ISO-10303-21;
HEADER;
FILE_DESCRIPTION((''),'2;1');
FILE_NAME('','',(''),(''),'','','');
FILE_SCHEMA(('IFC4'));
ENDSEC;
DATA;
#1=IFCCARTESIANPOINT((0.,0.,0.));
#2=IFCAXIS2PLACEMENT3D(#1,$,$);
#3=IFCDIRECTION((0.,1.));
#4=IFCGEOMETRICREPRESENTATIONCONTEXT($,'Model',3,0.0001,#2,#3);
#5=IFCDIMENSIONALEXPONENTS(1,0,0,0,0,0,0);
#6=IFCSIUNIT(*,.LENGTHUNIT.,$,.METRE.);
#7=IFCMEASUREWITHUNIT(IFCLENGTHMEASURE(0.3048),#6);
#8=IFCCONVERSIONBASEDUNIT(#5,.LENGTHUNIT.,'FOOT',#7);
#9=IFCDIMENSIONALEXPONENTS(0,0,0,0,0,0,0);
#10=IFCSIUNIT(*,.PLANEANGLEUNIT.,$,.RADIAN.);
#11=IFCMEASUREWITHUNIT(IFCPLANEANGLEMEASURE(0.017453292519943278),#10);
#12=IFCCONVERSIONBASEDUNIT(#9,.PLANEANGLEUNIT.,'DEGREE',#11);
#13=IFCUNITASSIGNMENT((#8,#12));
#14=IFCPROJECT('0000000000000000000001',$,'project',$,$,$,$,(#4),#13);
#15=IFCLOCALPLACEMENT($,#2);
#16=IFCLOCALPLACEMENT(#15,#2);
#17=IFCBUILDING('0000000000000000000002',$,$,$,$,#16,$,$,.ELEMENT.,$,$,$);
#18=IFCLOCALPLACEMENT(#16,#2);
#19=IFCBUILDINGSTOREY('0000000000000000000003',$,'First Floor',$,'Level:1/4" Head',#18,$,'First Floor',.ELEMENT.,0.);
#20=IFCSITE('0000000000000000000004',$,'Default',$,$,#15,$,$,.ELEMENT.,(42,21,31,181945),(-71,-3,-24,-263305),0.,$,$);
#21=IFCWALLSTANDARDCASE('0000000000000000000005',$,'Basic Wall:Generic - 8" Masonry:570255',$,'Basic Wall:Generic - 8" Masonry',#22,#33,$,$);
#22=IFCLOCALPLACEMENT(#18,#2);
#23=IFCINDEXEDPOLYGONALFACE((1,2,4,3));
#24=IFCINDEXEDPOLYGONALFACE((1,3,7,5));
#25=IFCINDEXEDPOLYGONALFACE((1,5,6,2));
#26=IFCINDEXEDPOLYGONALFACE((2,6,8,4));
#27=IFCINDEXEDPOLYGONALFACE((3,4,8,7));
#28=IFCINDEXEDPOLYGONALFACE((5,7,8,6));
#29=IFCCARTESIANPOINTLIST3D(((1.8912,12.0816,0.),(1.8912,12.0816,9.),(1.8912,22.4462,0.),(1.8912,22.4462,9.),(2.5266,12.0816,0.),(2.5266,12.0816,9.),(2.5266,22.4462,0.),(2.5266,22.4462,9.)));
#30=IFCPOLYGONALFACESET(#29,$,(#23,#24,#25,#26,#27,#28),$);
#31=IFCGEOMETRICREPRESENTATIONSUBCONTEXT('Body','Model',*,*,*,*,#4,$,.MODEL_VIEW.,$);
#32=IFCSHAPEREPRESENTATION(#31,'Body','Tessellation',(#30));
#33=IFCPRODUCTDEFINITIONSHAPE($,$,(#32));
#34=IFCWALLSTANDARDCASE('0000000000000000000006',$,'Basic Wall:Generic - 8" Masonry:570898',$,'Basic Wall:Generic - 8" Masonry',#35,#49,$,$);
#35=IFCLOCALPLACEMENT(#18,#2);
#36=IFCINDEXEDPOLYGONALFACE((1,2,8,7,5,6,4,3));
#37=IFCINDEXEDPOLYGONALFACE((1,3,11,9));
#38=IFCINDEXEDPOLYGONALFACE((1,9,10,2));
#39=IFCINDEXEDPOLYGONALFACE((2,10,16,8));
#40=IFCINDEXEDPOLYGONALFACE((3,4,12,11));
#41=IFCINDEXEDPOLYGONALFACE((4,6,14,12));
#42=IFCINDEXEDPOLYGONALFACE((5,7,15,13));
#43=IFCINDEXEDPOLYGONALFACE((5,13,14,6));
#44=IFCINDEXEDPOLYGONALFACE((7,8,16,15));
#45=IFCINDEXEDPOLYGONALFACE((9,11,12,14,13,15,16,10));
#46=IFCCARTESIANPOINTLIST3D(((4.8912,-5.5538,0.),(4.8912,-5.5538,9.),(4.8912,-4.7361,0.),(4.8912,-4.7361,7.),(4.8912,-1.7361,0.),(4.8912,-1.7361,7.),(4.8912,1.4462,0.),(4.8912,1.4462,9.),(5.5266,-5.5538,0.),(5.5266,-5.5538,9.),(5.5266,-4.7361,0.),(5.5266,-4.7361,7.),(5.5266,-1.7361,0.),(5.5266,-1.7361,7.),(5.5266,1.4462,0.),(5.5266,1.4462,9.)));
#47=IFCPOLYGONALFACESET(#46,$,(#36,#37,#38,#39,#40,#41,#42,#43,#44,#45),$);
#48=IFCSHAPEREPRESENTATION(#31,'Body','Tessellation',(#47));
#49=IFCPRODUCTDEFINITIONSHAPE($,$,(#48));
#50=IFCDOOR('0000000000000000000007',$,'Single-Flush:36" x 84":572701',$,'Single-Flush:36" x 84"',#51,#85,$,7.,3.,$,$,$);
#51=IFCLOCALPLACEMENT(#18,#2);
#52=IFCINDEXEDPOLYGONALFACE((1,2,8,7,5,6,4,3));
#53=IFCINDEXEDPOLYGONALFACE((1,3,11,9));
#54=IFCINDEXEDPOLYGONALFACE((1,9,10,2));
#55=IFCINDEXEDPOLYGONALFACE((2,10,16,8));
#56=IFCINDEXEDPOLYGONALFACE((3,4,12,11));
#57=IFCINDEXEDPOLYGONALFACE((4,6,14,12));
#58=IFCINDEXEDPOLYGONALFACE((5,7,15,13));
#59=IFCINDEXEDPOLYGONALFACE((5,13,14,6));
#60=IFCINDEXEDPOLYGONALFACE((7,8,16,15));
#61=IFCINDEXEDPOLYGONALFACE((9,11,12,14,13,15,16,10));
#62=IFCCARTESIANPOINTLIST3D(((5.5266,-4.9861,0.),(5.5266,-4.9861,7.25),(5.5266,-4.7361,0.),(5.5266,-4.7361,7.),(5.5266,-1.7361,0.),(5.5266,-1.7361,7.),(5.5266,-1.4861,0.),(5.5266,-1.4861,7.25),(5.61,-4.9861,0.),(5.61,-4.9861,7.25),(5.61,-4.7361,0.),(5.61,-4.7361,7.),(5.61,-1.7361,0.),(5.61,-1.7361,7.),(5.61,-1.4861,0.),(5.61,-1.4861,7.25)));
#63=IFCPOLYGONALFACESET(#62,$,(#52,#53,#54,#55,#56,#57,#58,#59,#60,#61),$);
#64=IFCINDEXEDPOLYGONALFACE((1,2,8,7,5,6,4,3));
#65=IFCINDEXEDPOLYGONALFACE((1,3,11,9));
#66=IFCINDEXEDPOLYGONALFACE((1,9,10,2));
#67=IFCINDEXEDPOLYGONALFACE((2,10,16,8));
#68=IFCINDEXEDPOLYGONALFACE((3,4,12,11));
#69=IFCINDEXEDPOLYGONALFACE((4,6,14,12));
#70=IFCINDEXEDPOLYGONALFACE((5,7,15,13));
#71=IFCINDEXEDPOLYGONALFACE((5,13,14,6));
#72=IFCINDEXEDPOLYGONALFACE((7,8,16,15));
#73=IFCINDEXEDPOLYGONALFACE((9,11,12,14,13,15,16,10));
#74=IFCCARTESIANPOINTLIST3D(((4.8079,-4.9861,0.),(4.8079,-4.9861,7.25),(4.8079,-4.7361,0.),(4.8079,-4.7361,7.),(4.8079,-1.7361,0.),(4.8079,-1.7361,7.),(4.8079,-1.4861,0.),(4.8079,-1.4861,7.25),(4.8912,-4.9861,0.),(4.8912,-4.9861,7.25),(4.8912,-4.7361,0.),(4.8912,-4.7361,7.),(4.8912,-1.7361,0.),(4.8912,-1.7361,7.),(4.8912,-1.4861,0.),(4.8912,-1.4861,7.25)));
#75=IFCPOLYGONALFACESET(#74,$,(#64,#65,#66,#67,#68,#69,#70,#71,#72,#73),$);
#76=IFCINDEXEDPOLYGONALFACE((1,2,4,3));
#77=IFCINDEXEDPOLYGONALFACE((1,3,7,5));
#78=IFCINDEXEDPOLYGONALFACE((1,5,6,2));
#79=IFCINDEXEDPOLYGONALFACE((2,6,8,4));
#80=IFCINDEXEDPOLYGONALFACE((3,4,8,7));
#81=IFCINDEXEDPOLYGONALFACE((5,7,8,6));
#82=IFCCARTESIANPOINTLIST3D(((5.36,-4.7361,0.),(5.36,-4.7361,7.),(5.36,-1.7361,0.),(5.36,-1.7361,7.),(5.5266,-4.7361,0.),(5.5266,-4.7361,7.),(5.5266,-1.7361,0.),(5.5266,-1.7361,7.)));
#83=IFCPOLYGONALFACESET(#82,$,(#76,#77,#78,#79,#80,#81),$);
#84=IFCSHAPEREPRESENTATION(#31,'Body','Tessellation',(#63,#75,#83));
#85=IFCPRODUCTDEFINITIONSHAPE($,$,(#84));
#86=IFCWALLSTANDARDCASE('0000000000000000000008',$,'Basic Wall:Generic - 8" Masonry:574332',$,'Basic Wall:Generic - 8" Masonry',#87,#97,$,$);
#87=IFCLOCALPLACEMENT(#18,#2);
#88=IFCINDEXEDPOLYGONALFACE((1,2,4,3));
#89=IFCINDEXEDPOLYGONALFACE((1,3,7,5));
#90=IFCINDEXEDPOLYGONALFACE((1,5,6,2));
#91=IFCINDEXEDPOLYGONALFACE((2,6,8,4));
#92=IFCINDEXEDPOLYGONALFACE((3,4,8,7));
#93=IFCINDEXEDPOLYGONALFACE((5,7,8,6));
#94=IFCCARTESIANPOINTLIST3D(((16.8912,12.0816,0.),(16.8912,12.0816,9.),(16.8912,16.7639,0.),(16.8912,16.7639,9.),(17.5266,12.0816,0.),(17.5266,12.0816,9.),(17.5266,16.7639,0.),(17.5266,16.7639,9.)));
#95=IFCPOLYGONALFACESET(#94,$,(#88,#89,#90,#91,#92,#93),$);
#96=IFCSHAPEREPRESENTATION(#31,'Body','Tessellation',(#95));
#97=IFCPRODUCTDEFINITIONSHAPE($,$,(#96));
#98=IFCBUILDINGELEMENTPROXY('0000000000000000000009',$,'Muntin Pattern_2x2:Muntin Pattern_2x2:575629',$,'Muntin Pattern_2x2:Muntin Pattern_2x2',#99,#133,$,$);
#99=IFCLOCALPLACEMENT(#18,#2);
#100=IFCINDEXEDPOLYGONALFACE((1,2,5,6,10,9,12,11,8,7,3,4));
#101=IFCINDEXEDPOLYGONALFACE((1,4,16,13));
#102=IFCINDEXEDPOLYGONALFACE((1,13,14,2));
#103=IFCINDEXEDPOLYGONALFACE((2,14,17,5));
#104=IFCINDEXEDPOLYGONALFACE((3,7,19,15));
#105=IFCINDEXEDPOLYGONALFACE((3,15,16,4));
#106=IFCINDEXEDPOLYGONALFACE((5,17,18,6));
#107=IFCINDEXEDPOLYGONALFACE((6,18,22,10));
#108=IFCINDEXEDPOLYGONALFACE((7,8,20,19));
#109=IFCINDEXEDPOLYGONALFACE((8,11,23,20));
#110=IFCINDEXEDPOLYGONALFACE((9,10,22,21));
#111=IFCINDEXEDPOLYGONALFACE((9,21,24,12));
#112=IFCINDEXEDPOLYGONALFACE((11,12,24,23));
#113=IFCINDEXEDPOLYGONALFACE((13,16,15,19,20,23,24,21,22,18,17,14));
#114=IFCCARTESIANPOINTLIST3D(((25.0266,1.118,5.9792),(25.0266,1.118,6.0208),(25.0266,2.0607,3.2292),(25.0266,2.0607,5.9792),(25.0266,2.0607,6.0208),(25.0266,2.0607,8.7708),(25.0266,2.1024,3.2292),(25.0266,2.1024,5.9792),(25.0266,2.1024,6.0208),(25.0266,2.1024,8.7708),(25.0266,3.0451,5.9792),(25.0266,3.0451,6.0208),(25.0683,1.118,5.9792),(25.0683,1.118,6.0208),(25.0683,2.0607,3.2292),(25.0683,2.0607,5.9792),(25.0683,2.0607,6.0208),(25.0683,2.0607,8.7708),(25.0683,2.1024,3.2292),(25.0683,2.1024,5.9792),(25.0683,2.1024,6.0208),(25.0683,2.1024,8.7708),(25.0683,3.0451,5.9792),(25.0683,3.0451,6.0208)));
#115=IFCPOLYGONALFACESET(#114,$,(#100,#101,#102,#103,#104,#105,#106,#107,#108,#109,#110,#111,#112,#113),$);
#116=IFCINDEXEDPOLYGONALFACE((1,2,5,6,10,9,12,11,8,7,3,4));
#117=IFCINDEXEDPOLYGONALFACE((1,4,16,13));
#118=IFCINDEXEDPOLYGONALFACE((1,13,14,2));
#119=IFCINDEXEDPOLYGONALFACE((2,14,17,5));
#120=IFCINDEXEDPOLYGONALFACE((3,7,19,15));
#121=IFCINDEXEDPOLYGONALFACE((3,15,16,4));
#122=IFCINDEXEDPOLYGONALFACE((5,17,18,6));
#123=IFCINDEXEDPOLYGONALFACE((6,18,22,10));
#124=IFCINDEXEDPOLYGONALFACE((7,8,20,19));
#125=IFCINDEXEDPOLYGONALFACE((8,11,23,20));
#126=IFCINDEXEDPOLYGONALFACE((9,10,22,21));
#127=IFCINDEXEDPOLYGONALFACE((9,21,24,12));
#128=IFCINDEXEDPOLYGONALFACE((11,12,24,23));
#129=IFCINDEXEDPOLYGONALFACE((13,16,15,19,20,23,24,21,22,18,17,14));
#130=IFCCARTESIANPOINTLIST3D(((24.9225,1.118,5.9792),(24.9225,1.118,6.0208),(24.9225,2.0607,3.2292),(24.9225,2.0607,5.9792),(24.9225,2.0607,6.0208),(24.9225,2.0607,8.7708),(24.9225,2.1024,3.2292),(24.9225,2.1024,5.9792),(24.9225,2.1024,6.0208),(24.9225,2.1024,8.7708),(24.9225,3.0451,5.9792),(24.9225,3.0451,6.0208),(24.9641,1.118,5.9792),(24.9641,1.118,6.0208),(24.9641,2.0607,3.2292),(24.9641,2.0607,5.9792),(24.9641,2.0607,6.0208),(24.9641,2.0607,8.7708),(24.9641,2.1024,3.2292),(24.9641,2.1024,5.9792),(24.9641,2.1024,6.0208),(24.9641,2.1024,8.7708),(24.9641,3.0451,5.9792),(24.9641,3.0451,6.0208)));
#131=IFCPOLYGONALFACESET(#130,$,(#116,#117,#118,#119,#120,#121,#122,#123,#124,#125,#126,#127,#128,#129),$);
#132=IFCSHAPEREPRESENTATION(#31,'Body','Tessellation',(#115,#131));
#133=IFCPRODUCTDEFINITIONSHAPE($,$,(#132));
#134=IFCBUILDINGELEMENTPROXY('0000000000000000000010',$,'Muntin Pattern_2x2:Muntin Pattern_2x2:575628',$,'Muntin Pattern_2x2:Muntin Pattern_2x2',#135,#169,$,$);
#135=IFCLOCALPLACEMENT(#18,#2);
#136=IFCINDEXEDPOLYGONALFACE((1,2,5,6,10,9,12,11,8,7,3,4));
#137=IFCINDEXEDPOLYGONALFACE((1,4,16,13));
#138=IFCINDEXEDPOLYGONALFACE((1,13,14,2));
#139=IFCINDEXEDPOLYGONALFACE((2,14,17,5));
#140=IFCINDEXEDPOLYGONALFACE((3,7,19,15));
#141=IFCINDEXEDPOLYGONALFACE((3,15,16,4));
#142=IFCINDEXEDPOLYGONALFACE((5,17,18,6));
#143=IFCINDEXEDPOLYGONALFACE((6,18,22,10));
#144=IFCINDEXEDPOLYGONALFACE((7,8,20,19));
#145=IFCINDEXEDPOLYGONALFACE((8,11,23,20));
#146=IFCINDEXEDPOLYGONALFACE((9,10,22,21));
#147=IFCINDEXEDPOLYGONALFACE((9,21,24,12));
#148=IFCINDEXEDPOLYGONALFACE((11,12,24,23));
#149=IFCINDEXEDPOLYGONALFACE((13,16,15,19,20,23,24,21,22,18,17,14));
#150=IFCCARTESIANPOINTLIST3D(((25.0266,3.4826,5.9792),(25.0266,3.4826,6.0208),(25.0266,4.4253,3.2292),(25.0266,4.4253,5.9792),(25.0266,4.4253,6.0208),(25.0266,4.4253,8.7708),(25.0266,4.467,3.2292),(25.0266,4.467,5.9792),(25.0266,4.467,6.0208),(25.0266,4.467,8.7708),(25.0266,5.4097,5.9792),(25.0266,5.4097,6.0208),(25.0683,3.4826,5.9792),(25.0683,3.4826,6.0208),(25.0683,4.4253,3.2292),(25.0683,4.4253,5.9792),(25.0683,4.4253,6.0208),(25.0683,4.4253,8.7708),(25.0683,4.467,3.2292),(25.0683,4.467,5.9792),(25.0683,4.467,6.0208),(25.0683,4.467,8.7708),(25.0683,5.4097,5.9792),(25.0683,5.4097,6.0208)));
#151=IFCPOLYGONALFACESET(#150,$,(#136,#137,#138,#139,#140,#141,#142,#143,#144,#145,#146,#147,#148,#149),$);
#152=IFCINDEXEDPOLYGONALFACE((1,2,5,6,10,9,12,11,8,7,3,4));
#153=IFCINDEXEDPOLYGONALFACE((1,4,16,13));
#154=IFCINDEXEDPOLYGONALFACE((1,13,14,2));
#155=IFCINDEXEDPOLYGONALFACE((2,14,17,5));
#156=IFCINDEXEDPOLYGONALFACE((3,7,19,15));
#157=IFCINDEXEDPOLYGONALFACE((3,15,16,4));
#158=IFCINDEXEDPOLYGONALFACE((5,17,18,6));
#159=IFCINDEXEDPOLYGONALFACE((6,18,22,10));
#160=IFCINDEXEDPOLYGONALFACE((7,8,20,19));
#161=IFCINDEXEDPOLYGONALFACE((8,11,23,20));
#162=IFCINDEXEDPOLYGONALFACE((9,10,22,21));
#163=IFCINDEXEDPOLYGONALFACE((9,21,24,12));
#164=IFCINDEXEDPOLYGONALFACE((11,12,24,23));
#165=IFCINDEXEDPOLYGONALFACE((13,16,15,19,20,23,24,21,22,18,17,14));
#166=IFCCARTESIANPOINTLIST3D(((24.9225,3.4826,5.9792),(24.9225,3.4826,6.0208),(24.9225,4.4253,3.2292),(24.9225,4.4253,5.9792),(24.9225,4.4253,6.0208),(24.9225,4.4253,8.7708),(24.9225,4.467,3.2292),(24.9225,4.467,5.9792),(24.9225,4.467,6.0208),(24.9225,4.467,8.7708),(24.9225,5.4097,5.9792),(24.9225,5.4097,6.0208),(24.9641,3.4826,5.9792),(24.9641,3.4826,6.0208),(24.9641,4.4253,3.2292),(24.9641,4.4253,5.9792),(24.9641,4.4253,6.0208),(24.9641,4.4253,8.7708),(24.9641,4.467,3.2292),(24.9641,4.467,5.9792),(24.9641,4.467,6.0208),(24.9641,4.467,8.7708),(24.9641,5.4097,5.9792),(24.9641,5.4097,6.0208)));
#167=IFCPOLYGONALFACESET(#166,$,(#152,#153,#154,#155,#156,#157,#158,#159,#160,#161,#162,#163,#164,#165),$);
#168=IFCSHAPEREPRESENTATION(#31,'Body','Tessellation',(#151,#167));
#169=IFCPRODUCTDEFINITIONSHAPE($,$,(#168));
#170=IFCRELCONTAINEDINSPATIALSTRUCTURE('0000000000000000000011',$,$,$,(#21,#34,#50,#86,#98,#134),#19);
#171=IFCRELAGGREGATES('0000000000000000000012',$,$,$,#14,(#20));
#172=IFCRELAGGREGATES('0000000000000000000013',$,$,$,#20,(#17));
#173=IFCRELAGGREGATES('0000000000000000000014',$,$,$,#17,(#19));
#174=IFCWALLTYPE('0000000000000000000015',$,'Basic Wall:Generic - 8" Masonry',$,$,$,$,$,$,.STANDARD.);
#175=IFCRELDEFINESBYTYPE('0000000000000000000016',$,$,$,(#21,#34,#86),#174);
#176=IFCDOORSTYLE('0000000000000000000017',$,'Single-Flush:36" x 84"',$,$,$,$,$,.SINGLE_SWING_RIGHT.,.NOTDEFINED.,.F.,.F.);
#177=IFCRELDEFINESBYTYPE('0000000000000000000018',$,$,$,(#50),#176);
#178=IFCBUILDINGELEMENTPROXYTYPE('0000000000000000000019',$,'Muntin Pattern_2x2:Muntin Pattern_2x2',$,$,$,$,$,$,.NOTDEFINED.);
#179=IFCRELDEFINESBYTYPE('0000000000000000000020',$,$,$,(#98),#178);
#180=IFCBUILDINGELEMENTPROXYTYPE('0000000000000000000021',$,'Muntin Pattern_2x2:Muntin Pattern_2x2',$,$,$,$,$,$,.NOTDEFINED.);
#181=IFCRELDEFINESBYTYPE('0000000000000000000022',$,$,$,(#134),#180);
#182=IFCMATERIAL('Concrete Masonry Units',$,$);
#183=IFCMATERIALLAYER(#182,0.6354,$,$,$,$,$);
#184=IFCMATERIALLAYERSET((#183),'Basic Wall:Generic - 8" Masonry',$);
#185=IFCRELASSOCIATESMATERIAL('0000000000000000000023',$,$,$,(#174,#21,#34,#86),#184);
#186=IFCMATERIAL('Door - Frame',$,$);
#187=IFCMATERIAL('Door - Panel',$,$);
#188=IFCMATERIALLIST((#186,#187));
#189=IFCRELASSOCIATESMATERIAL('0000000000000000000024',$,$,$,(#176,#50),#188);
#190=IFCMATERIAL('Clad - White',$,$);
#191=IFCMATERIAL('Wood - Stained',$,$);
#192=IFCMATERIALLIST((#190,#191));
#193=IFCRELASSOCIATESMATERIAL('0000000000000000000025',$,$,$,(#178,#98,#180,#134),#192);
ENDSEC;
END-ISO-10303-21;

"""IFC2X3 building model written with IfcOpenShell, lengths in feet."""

from ifc_helpers import new_model, entity, si_unit, converted_unit, direction, frame, frame_2d, origin, place, context, subcontext, project, spatial, polyline, rectangle, outline, extrude, source, transform, mapped, material, material_list, layer, layer_set, layer_usage, type_object, type_shapes, element, fill, save


model = new_model("IFC2X3")

# Units and contexts
model_context = context("Model", 3, precision=0.0001, world=origin(), true_north=direction((0.0, 1.0)))
body_context = subcontext(model_context, "Body", "Model", "MODEL_VIEW")
ifc_project = project(units=[converted_unit("LENGTHUNIT", "FOOT", entity("IfcLengthMeasure", 0.3048), si_unit("LENGTHUNIT", "METRE"), dimensions=[1, 0, 0, 0, 0, 0, 0]), converted_unit("PLANEANGLEUNIT", "DEGREE", entity("IfcPlaneAngleMeasure", 0.017453292519943278), si_unit("PLANEANGLEUNIT", "RADIAN"), dimensions=[0, 0, 0, 0, 0, 0, 0])], contexts=[model_context])

# Site, building, storey
site_placement = place(None, origin())
site = spatial("IfcSite", under=ifc_project, at=site_placement, Name="Default", CompositionType="ELEMENT", RefLatitude=(42, 21, 31, 181945), RefLongitude=(-71, -3, -24, -263305), RefElevation=0.0)
building_placement = place(site_placement, origin())
building = spatial("IfcBuilding", under=site, at=building_placement, CompositionType="ELEMENT")
storey_placement = place(building_placement, origin())
storey = spatial("IfcBuildingStorey", under=building, at=storey_placement, Name="First Floor", ObjectType="Level:1/4\" Head", LongName="First Floor", CompositionType="ELEMENT", Elevation=0.0)

# Shared definitions
ifc_material_1 = material(Name="Concrete Masonry Units")
ifc_layer = layer(ifc_material_1, 0.6354)
ifc_layer_set = layer_set([ifc_layer], Name="Basic Wall:Generic - 8\" Masonry")
wall_type = type_object("IfcWallType", Name="Basic Wall:Generic - 8\" Masonry", PredefinedType="STANDARD", material=ifc_layer_set)

# Wall
ifc_layer_usage_1 = layer_usage(ifc_layer_set, "AXIS2", "NEGATIVE", 0.3177)
wall_1_placement = place(storey_placement, frame((2.2089, 22.4462, 0.0), z_axis=(0.0, 0.0, 1.0), x_axis=(0.0, -1.0, 0.0)))
element("IfcWallStandardCase", 1, at=wall_1_placement, inside=storey, type_object=wall_type, material=ifc_layer_usage_1, Name="Basic Wall:Generic - 8\" Masonry:570255", ObjectType="Basic Wall:Generic - 8\" Masonry", context=body_context, shape_type="SweptSolid", body=[
    extrude(rectangle(XDim=10.3646, YDim=0.6354, at=frame_2d((5.1823, 0.0), x_axis=(-1.0, 0.0))), origin(), (0.0, 0.0, 1.0), 9.0),
])

# Wall, opening, door
ifc_layer_usage_2 = layer_usage(ifc_layer_set, "AXIS2", "NEGATIVE", 0.3177)
wall_2_placement = place(storey_placement, frame((5.2089, 1.4462, 0.0), z_axis=(0.0, 0.0, 1.0), x_axis=(0.0, -1.0, 0.0)))
wall_2 = element("IfcWallStandardCase", 2, at=wall_2_placement, inside=storey, type_object=wall_type, material=ifc_layer_usage_2, Name="Basic Wall:Generic - 8\" Masonry:570898", ObjectType="Basic Wall:Generic - 8\" Masonry", context=body_context, shape_type="SweptSolid", body=[
    extrude(rectangle(XDim=7.0, YDim=0.6354, at=frame_2d((3.5, 0.0), x_axis=(1.0, 0.0))), origin(), (0.0, 0.0, 1.0), 9.0),
])
opening_1_placement = place(wall_2_placement, frame((3.1823, -0.3177, 0.0)))
opening_1 = element("IfcOpeningElement", 3, at=opening_1_placement, cuts=wall_2, ObjectType="Opening", context=body_context, shape_type="SweptSolid", body=[
    extrude(rectangle(XDim=3.0, YDim=7.0, at=frame_2d((3.5, 1.5), x_axis=(0.0, 1.0))), frame((0.0, 0.0, 0.0), z_axis=(0.0, 1.0, 0.0), x_axis=(0.0, 0.0, 1.0)), (0.0, 0.0, 1.0), 0.6354),
])
ifc_material_2 = material(Name="Door - Frame")
ifc_material_3 = material(Name="Door - Panel")
ifc_material_list_1 = material_list([ifc_material_2, ifc_material_3])
door_style = type_object("IfcDoorStyle", Name="Single-Flush:36\" x 84\"", ConstructionType="NOTDEFINED", OperationType="SINGLE_SWING_RIGHT", ParameterTakesPrecedence=False, Sizeable=False, material=ifc_material_list_1)
shared_shape_1 = source(origin(), body_context, "Body", "SweptSolid", [
    extrude(outline(polyline([(-1.75, -3.6875), (1.75, -3.6875), (1.75, 3.5625), (1.5, 3.5625), (1.5, -3.4375), (-1.5, -3.4375), (-1.5, 3.5625), (-1.75, 3.5625), (-1.75, -3.6875)])), frame((1.5, 0.6354, 3.5625), z_axis=(0.0, 1.0, 0.0), x_axis=(1.0, 0.0, 0.0)), (0.0, 0.0, 1.0), 0.0833),
    extrude(outline(polyline([(-3.6875, -1.75), (3.5625, -1.75), (3.5625, -1.5), (-3.4375, -1.5), (-3.4375, 1.5), (3.5625, 1.5), (3.5625, 1.75), (-3.6875, 1.75), (-3.6875, -1.75)])), frame((1.5, -0.0833, 3.5625), z_axis=(0.0, 1.0, 0.0), x_axis=(0.0, 0.0, -1.0)), (0.0, 0.0, 1.0), 0.0833),
    extrude(rectangle(XDim=0.1667, YDim=3.0, at=frame_2d((0.0, 0.0), x_axis=(1.0, 0.0))), frame((1.5, 0.5521, 0.0), z_axis=(0.0, 0.0, 1.0), x_axis=(0.0, 1.0, 0.0)), (0.0, 0.0, 1.0), 7.0),
])
type_shapes(door_style, [shared_shape_1])
door_placement = place(opening_1_placement, origin())
door = element("IfcDoor", 4, at=door_placement, inside=storey, type_object=door_style, material=ifc_material_list_1, Name="Single-Flush:36\" x 84\":572701", ObjectType="Single-Flush:36\" x 84\"", OverallHeight=7.0, OverallWidth=3.0, context=body_context, shape_type="MappedRepresentation", body=[
    mapped(shared_shape_1, transform((0.0, 0.0, 0.0), scale=1.0)),
])
fill(opening_1, door)

# Wall
ifc_layer_usage_3 = layer_usage(ifc_layer_set, "AXIS2", "NEGATIVE", 0.3177)
wall_3_placement = place(storey_placement, frame((17.2089, 12.0816, 0.0), z_axis=(0.0, 0.0, 1.0), x_axis=(0.0, 1.0, 0.0)))
element("IfcWallStandardCase", 5, at=wall_3_placement, inside=storey, type_object=wall_type, material=ifc_layer_usage_3, Name="Basic Wall:Generic - 8\" Masonry:574332", ObjectType="Basic Wall:Generic - 8\" Masonry", context=body_context, shape_type="SweptSolid", body=[
    extrude(rectangle(XDim=4.6823, YDim=0.6354, at=frame_2d((2.3411, 0.0), x_axis=(-1.0, 0.0))), origin(), (0.0, 0.0, 1.0), 9.0),
])

# Building element proxies
ifc_material_4 = material(Name="Clad - White")
ifc_material_5 = material(Name="Wood - Stained")
ifc_material_list_2 = material_list([ifc_material_4, ifc_material_5])
building_element_proxy_type_1 = type_object("IfcBuildingElementProxyType", Name="Muntin Pattern_2x2:Muntin Pattern_2x2", PredefinedType="NOTDEFINED", material=ifc_material_list_2)
shared_shape_2 = source(origin(), body_context, "Body", "SweptSolid", [
    extrude(outline(polyline([(0.0208, -0.0208), (2.7708, -0.0208), (2.7708, 0.0208), (0.0208, 0.0208), (0.0208, 0.9635), (-0.0208, 0.9635), (-0.0208, 0.0208), (-2.7708, 0.0208), (-2.7708, -0.0208), (-0.0208, -0.0208), (-0.0208, -0.9635), (0.0208, -0.9635), (0.0208, -0.0208)])), frame((0.0, -0.0729, 2.7708), z_axis=(0.0, 1.0, 0.0), x_axis=(0.0, 0.0, 1.0)), (0.0, 0.0, 1.0), 0.0417),
    extrude(outline(polyline([(0.0208, -0.0208), (2.7708, -0.0208), (2.7708, 0.0208), (0.0208, 0.0208), (0.0208, 0.9635), (-0.0208, 0.9635), (-0.0208, 0.0208), (-2.7708, 0.0208), (-2.7708, -0.0208), (-0.0208, -0.0208), (-0.0208, -0.9635), (0.0208, -0.9635), (0.0208, -0.0208)])), frame((0.0, 0.0313, 2.7708), z_axis=(0.0, 1.0, 0.0), x_axis=(0.0, 0.0, 1.0)), (0.0, 0.0, 1.0), 0.0417),
])
type_shapes(building_element_proxy_type_1, [shared_shape_2])
proxy_1_placement = place(storey_placement, frame((24.9954, 2.0816, 3.2292), z_axis=(0.0, 0.0, 1.0), x_axis=(0.0, 1.0, 0.0)))
element("IfcBuildingElementProxy", 6, at=proxy_1_placement, inside=storey, type_object=building_element_proxy_type_1, material=ifc_material_list_2, Name="Muntin Pattern_2x2:Muntin Pattern_2x2:575629", ObjectType="Muntin Pattern_2x2:Muntin Pattern_2x2", context=body_context, shape_type="MappedRepresentation", body=[
    mapped(shared_shape_2, transform((0.0, 0.0, 0.0), scale=1.0)),
])
building_element_proxy_type_2 = type_object("IfcBuildingElementProxyType", Name="Muntin Pattern_2x2:Muntin Pattern_2x2", PredefinedType="NOTDEFINED", material=ifc_material_list_2)
shared_shape_3 = source(origin(), body_context, "Body", "SweptSolid", [
    extrude(outline(polyline([(0.0208, -0.0208), (2.7708, -0.0208), (2.7708, 0.0208), (0.0208, 0.0208), (0.0208, 0.9635), (-0.0208, 0.9635), (-0.0208, 0.0208), (-2.7708, 0.0208), (-2.7708, -0.0208), (-0.0208, -0.0208), (-0.0208, -0.9635), (0.0208, -0.9635), (0.0208, -0.0208)])), frame((0.0, 0.0313, 2.7708), z_axis=(0.0, 1.0, 0.0), x_axis=(0.0, 0.0, 1.0)), (0.0, 0.0, 1.0), 0.0417),
    extrude(outline(polyline([(0.0208, -0.0208), (2.7708, -0.0208), (2.7708, 0.0208), (0.0208, 0.0208), (0.0208, 0.9635), (-0.0208, 0.9635), (-0.0208, 0.0208), (-2.7708, 0.0208), (-2.7708, -0.0208), (-0.0208, -0.0208), (-0.0208, -0.9635), (0.0208, -0.9635), (0.0208, -0.0208)])), frame((0.0, -0.0729, 2.7708), z_axis=(0.0, 1.0, 0.0), x_axis=(0.0, 0.0, 1.0)), (0.0, 0.0, 1.0), 0.0417),
])
type_shapes(building_element_proxy_type_2, [shared_shape_3])
proxy_2_placement = place(storey_placement, frame((24.9954, 4.4462, 3.2292), z_axis=(0.0, 0.0, 1.0), x_axis=(0.0, -1.0, 0.0)))
element("IfcBuildingElementProxy", 7, at=proxy_2_placement, inside=storey, type_object=building_element_proxy_type_2, material=ifc_material_list_2, Name="Muntin Pattern_2x2:Muntin Pattern_2x2:575628", ObjectType="Muntin Pattern_2x2:Muntin Pattern_2x2", context=body_context, shape_type="MappedRepresentation", body=[
    mapped(shared_shape_3, transform((0.0, 0.0, 0.0), scale=1.0)),
])

save(model, "model.ifc")
